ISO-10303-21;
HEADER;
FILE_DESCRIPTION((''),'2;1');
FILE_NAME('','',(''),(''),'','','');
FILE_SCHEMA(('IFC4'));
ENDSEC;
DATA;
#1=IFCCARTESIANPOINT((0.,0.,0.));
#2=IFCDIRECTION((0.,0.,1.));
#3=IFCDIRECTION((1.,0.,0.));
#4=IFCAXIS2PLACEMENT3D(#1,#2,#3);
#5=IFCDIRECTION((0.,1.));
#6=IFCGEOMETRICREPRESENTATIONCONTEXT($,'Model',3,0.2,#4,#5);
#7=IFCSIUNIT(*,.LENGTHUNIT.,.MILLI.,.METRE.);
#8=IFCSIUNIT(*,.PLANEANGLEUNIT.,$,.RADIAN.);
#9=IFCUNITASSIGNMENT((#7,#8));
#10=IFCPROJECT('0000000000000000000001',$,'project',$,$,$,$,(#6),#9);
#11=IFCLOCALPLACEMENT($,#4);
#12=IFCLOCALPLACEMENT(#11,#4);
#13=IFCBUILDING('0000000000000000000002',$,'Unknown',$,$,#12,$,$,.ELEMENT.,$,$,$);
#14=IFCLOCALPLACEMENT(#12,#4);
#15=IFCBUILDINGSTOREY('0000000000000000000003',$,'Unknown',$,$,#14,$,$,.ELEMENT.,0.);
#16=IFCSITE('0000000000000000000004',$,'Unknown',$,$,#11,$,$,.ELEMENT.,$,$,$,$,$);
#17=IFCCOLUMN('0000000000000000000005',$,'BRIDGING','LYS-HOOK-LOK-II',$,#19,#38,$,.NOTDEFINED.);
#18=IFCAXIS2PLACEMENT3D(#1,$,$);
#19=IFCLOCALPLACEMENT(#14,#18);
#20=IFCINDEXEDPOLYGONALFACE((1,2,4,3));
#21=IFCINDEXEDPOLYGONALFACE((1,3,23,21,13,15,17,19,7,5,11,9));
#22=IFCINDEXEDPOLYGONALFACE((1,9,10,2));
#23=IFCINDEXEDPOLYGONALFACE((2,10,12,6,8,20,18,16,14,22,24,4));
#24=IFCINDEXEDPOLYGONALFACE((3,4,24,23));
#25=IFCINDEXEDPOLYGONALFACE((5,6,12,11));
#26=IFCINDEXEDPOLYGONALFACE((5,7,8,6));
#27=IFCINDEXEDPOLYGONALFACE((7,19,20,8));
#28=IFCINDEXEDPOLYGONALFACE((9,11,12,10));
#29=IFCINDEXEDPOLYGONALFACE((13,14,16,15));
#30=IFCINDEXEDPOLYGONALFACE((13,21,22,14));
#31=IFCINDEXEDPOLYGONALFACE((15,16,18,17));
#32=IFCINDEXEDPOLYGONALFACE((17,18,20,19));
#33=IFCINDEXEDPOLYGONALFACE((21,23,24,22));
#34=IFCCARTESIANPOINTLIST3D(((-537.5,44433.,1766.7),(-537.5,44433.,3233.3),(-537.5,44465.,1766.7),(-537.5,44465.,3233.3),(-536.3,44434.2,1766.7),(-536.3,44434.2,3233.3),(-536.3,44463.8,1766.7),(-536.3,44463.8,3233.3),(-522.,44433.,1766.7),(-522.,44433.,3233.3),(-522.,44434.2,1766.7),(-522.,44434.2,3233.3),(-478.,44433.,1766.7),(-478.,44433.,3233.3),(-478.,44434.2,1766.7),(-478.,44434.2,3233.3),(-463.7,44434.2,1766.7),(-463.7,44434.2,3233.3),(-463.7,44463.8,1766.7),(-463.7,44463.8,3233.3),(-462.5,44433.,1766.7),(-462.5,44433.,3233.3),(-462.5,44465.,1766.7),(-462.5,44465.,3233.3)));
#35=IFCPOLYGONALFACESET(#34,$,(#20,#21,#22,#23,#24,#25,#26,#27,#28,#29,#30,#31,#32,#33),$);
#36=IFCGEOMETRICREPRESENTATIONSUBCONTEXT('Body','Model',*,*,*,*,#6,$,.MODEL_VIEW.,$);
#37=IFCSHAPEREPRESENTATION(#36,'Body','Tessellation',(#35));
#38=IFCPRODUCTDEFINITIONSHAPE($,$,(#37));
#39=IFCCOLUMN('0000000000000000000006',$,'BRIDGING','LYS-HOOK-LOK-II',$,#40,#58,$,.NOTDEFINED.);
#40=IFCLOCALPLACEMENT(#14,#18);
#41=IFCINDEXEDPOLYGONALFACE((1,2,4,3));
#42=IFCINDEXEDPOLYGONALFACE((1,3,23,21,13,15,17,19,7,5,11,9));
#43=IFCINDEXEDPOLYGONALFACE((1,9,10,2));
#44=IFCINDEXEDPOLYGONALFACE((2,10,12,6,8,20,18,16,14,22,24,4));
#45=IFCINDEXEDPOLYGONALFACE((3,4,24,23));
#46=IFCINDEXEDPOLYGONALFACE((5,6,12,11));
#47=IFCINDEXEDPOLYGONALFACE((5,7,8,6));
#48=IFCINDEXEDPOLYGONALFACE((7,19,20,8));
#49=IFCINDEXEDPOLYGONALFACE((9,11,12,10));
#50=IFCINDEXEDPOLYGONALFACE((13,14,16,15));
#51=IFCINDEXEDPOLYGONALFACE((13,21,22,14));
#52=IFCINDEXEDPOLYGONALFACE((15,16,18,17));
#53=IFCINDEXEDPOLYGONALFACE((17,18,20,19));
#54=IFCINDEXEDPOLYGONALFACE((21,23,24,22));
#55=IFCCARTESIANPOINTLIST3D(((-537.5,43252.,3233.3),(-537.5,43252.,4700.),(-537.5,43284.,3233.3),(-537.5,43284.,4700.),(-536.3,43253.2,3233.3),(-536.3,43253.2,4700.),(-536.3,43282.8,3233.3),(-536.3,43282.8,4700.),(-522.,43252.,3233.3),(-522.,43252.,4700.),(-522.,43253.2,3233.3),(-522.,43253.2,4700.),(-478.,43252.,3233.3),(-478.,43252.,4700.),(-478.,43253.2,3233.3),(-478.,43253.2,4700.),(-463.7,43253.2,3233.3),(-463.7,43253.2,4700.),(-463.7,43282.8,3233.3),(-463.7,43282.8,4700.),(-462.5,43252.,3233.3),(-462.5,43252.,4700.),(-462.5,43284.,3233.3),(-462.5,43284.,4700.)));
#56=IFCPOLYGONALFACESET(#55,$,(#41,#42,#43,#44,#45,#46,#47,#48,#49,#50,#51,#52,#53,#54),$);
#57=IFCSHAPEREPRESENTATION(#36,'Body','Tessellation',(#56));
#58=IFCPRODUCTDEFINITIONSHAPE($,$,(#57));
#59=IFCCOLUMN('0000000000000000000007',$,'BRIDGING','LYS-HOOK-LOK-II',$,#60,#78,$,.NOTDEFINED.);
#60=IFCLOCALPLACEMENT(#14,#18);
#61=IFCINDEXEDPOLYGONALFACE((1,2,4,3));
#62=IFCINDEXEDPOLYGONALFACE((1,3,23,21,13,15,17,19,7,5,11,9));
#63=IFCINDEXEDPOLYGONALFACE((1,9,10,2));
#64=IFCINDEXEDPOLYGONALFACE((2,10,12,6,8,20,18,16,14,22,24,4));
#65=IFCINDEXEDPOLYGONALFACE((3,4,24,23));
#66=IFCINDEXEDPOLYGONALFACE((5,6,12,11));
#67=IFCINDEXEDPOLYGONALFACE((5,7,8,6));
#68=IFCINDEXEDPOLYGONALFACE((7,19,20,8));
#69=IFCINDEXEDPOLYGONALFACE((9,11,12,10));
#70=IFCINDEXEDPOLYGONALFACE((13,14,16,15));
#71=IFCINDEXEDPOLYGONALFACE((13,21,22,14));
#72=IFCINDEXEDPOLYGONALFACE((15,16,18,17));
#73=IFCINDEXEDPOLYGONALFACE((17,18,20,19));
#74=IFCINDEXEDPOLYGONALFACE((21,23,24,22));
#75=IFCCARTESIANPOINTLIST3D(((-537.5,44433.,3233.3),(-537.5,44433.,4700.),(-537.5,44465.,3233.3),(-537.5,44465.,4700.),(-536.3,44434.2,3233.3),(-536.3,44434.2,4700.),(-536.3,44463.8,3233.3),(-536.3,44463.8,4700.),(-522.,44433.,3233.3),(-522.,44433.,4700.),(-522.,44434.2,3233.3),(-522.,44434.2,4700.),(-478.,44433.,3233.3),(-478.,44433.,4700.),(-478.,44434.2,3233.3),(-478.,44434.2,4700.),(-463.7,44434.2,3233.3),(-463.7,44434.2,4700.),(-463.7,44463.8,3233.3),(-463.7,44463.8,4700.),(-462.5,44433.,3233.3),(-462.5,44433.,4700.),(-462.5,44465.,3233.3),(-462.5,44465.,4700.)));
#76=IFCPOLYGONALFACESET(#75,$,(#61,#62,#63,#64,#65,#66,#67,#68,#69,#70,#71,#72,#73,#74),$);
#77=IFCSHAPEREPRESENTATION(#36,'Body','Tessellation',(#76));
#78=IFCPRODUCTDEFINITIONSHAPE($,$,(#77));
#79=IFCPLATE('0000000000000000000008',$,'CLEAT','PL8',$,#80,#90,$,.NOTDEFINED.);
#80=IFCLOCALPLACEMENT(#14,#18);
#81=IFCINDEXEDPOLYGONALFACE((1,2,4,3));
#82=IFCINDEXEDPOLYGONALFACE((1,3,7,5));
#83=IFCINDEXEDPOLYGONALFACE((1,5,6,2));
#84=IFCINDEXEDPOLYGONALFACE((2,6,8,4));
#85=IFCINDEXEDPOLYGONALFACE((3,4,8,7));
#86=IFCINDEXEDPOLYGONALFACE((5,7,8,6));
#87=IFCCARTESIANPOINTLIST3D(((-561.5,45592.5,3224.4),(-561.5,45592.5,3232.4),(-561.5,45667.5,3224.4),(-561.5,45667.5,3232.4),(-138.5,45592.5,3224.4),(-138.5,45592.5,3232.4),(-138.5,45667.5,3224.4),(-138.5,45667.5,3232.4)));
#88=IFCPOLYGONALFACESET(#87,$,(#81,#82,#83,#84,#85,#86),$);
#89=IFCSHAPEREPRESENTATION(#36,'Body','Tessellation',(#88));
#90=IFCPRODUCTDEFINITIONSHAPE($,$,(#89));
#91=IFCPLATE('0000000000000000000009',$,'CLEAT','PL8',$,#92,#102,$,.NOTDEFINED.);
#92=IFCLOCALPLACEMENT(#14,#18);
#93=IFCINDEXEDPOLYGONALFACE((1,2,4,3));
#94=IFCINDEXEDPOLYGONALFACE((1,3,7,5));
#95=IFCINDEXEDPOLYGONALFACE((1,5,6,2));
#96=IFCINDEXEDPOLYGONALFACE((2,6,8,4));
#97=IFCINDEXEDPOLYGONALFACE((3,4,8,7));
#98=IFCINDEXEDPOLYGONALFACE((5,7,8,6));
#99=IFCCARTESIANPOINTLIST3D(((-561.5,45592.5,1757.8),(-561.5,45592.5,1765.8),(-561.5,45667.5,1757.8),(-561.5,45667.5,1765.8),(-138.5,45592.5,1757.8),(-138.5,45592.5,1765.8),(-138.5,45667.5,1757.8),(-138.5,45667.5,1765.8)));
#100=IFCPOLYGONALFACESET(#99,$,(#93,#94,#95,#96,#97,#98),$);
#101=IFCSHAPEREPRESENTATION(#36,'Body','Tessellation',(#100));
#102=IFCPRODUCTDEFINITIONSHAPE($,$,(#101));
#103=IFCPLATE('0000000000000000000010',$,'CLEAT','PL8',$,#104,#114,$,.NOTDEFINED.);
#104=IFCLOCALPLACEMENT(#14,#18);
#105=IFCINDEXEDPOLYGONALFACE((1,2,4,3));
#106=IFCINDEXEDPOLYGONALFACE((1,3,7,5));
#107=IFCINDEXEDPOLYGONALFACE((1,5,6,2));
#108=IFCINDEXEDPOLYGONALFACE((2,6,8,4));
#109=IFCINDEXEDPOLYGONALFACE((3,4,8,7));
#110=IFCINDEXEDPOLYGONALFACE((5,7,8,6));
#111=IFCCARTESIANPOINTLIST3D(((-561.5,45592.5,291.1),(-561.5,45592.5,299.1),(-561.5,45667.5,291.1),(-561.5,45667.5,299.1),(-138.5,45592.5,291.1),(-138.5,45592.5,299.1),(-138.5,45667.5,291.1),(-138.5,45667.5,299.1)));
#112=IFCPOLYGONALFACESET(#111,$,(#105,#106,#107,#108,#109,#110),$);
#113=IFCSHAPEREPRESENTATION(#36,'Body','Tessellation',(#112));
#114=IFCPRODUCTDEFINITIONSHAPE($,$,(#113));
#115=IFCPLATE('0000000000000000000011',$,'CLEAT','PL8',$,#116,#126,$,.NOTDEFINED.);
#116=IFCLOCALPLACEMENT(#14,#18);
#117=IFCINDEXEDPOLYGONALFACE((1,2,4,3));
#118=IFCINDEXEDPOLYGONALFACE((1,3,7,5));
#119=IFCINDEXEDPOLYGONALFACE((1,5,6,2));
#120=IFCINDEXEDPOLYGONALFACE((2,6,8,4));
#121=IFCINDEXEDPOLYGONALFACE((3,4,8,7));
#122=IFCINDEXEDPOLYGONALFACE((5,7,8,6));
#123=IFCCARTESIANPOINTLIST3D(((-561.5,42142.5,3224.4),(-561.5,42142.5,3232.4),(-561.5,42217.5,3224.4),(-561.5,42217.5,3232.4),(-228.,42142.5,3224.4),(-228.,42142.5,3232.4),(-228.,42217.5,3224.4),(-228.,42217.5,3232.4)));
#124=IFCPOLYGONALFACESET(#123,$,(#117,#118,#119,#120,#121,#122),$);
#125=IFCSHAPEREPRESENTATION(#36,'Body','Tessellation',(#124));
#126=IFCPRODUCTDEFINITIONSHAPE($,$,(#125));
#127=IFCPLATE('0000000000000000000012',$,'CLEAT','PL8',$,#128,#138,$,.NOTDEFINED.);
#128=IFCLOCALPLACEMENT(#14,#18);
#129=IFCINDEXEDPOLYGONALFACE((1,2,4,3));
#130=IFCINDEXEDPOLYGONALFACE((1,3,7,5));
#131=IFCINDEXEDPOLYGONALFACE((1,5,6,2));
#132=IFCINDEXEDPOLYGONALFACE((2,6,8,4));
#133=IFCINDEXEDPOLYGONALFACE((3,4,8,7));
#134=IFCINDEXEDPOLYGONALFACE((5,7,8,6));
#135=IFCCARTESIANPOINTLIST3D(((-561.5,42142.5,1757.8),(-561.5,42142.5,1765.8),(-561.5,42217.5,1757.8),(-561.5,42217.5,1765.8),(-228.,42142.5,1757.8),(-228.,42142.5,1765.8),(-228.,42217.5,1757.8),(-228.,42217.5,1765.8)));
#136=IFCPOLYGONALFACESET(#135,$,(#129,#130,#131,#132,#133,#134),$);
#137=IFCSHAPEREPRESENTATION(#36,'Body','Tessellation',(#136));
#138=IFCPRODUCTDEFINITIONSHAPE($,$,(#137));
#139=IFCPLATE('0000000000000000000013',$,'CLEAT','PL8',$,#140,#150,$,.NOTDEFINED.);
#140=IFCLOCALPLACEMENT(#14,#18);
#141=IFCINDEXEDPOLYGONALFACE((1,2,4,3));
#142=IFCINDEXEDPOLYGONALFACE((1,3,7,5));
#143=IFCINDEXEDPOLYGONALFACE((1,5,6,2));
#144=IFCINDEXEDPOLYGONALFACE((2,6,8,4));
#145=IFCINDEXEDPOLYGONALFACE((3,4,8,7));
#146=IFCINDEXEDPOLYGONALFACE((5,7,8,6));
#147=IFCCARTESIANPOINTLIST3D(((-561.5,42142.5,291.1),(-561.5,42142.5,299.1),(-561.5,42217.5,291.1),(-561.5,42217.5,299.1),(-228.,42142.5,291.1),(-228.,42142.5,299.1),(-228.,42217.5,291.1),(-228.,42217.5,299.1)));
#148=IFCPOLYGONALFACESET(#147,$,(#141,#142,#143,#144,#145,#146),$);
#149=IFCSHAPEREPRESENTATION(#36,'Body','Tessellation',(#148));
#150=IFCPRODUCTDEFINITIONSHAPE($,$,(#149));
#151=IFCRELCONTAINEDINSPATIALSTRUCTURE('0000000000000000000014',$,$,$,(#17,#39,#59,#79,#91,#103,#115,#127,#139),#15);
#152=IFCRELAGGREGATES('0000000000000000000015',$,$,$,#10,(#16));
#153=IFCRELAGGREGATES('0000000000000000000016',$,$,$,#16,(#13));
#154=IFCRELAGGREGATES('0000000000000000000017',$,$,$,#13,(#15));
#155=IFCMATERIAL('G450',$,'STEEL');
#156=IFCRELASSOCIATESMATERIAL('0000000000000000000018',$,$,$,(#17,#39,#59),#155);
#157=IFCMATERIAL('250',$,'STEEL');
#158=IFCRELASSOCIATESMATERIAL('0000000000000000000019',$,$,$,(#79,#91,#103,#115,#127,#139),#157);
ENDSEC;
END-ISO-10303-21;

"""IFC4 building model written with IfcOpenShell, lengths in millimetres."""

from ifc_helpers import new_model, si_unit, direction, frame, origin_with_axes, place, context, subcontext, project, spatial, line, indexed_curve, outline, extrude, material, element, save


model = new_model("IFC4")

# Units and contexts
model_context = context("Model", 3, precision=0.2, world=origin_with_axes(), true_north=direction((0.0, 1.0)))
body_context = subcontext(model_context, "Body", "Model", "MODEL_VIEW")
ifc_project = project(units=[si_unit("LENGTHUNIT", "METRE", prefix="MILLI"), si_unit("PLANEANGLEUNIT", "RADIAN")], contexts=[model_context])

# Site, building, storey
site_placement = place(None, origin_with_axes())
site = spatial("IfcSite", under=ifc_project, at=site_placement, Name="Unknown", CompositionType="ELEMENT")
building_placement = place(site_placement, origin_with_axes())
building = spatial("IfcBuilding", under=site, at=building_placement, Name="Unknown", CompositionType="ELEMENT")
storey_placement = place(building_placement, origin_with_axes())
storey = spatial("IfcBuildingStorey", under=building, at=storey_placement, Name="Unknown", CompositionType="ELEMENT", Elevation=0.0)

# Columns
ifc_material_1 = material(Name="G450", Category="STEEL")
for number, where, z_axis, x_axis, name in (
    (1, (-500.0, 44449.0, 1766.7), (0.0, -1.0, 0.0), (0.0, 0.0, 1.0), "BRIDGING"),
):
    element("IfcColumn", number, at=place(storey_placement, frame(where, z_axis=z_axis, x_axis=x_axis)), inside=storey, material=ifc_material_1, Name=name, Description="LYS-HOOK-LOK-II", PredefinedType="NOTDEFINED", context=body_context, shape_type="SolidModel", body=[
        extrude(outline(indexed_curve([(16.0, -37.5), (16.0, -22.0), (14.8, -22.0), (14.8, -36.3), (-14.8, -36.3), (-14.8, 36.3), (14.8, 36.3), (14.8, 22.0), (16.0, 22.0), (16.0, 37.5), (-16.0, 37.5), (-16.0, -37.5)], segments=[line(1, 2, 3, 4, 5, 6, 7, 8, 9, 10, 11, 12, 1)])), frame((0.0, 0.0, 0.0), z_axis=(-1.0, 0.0, 0.0), x_axis=(0.0, 0.0, 1.0)), (0.0, 0.0, -1.0), 1466.6),
    ])
for number, where, z_axis, x_axis, name in (
    (2, (-500.0, 43268.0, 3233.3), (0.0, -1.0, 0.0), (0.0, 0.0, 1.0), "BRIDGING"),
    (3, (-500.0, 44449.0, 3233.3), (0.0, -1.0, 0.0), (0.0, 0.0, 1.0), "BRIDGING"),
):
    element("IfcColumn", number, at=place(storey_placement, frame(where, z_axis=z_axis, x_axis=x_axis)), inside=storey, material=ifc_material_1, Name=name, Description="LYS-HOOK-LOK-II", PredefinedType="NOTDEFINED", context=body_context, shape_type="SolidModel", body=[
        extrude(outline(indexed_curve([(16.0, -37.5), (16.0, -22.0), (14.8, -22.0), (14.8, -36.3), (-14.8, -36.3), (-14.8, 36.3), (14.8, 36.3), (14.8, 22.0), (16.0, 22.0), (16.0, 37.5), (-16.0, 37.5), (-16.0, -37.5)], segments=[line(1, 2, 3, 4, 5, 6, 7, 8, 9, 10, 11, 12, 1)])), frame((0.0, 0.0, 0.0), z_axis=(-1.0, 0.0, 0.0), x_axis=(0.0, 0.0, 1.0)), (0.0, 0.0, -1.0), 1466.7),
    ])

# Plates
ifc_material_2 = material(Name="250", Category="STEEL")
for number, where, z_axis, x_axis, name in (
    (4, (-138.5, 45592.5, 3228.4), (0.0, 0.0, 1.0), (0.0, 1.0, 0.0), "CLEAT"),
    (5, (-138.5, 45592.5, 1761.8), (0.0, 0.0, 1.0), (0.0, 1.0, 0.0), "CLEAT"),
    (6, (-138.5, 45592.5, 295.1), (0.0, 0.0, 1.0), (0.0, 1.0, 0.0), "CLEAT"),
):
    element("IfcPlate", number, at=place(storey_placement, frame(where, z_axis=z_axis, x_axis=x_axis)), inside=storey, material=ifc_material_2, Name=name, Description="PL8", PredefinedType="NOTDEFINED", context=body_context, shape_type="SolidModel", body=[
        extrude(outline(indexed_curve([(0.0, 0.0), (75.0, 0.0), (75.0, 423.0), (0.0, 423.0)], segments=[line(1, 2, 3, 4, 1)])), frame((0.0, 0.0, 4.0), z_axis=(0.0, 0.0, 1.0), x_axis=(1.0, 0.0, 0.0)), (0.0, 0.0, -1.0), 8.0),
    ])
for number, where, z_axis, x_axis, name in (
    (7, (-228.0, 42142.5, 3228.4), (0.0, 0.0, 1.0), (0.0, 1.0, 0.0), "CLEAT"),
    (8, (-228.0, 42142.5, 1761.8), (0.0, 0.0, 1.0), (0.0, 1.0, 0.0), "CLEAT"),
    (9, (-228.0, 42142.5, 295.1), (0.0, 0.0, 1.0), (0.0, 1.0, 0.0), "CLEAT"),
):
    element("IfcPlate", number, at=place(storey_placement, frame(where, z_axis=z_axis, x_axis=x_axis)), inside=storey, material=ifc_material_2, Name=name, Description="PL8", PredefinedType="NOTDEFINED", context=body_context, shape_type="SolidModel", body=[
        extrude(outline(indexed_curve([(0.0, 0.0), (75.0, 0.0), (75.0, 333.5), (0.0, 333.5)], segments=[line(1, 2, 3, 4, 1)])), frame((0.0, 0.0, 4.0), z_axis=(0.0, 0.0, 1.0), x_axis=(1.0, 0.0, 0.0)), (0.0, 0.0, -1.0), 8.0),
    ])

save(model, "model.ifc")
